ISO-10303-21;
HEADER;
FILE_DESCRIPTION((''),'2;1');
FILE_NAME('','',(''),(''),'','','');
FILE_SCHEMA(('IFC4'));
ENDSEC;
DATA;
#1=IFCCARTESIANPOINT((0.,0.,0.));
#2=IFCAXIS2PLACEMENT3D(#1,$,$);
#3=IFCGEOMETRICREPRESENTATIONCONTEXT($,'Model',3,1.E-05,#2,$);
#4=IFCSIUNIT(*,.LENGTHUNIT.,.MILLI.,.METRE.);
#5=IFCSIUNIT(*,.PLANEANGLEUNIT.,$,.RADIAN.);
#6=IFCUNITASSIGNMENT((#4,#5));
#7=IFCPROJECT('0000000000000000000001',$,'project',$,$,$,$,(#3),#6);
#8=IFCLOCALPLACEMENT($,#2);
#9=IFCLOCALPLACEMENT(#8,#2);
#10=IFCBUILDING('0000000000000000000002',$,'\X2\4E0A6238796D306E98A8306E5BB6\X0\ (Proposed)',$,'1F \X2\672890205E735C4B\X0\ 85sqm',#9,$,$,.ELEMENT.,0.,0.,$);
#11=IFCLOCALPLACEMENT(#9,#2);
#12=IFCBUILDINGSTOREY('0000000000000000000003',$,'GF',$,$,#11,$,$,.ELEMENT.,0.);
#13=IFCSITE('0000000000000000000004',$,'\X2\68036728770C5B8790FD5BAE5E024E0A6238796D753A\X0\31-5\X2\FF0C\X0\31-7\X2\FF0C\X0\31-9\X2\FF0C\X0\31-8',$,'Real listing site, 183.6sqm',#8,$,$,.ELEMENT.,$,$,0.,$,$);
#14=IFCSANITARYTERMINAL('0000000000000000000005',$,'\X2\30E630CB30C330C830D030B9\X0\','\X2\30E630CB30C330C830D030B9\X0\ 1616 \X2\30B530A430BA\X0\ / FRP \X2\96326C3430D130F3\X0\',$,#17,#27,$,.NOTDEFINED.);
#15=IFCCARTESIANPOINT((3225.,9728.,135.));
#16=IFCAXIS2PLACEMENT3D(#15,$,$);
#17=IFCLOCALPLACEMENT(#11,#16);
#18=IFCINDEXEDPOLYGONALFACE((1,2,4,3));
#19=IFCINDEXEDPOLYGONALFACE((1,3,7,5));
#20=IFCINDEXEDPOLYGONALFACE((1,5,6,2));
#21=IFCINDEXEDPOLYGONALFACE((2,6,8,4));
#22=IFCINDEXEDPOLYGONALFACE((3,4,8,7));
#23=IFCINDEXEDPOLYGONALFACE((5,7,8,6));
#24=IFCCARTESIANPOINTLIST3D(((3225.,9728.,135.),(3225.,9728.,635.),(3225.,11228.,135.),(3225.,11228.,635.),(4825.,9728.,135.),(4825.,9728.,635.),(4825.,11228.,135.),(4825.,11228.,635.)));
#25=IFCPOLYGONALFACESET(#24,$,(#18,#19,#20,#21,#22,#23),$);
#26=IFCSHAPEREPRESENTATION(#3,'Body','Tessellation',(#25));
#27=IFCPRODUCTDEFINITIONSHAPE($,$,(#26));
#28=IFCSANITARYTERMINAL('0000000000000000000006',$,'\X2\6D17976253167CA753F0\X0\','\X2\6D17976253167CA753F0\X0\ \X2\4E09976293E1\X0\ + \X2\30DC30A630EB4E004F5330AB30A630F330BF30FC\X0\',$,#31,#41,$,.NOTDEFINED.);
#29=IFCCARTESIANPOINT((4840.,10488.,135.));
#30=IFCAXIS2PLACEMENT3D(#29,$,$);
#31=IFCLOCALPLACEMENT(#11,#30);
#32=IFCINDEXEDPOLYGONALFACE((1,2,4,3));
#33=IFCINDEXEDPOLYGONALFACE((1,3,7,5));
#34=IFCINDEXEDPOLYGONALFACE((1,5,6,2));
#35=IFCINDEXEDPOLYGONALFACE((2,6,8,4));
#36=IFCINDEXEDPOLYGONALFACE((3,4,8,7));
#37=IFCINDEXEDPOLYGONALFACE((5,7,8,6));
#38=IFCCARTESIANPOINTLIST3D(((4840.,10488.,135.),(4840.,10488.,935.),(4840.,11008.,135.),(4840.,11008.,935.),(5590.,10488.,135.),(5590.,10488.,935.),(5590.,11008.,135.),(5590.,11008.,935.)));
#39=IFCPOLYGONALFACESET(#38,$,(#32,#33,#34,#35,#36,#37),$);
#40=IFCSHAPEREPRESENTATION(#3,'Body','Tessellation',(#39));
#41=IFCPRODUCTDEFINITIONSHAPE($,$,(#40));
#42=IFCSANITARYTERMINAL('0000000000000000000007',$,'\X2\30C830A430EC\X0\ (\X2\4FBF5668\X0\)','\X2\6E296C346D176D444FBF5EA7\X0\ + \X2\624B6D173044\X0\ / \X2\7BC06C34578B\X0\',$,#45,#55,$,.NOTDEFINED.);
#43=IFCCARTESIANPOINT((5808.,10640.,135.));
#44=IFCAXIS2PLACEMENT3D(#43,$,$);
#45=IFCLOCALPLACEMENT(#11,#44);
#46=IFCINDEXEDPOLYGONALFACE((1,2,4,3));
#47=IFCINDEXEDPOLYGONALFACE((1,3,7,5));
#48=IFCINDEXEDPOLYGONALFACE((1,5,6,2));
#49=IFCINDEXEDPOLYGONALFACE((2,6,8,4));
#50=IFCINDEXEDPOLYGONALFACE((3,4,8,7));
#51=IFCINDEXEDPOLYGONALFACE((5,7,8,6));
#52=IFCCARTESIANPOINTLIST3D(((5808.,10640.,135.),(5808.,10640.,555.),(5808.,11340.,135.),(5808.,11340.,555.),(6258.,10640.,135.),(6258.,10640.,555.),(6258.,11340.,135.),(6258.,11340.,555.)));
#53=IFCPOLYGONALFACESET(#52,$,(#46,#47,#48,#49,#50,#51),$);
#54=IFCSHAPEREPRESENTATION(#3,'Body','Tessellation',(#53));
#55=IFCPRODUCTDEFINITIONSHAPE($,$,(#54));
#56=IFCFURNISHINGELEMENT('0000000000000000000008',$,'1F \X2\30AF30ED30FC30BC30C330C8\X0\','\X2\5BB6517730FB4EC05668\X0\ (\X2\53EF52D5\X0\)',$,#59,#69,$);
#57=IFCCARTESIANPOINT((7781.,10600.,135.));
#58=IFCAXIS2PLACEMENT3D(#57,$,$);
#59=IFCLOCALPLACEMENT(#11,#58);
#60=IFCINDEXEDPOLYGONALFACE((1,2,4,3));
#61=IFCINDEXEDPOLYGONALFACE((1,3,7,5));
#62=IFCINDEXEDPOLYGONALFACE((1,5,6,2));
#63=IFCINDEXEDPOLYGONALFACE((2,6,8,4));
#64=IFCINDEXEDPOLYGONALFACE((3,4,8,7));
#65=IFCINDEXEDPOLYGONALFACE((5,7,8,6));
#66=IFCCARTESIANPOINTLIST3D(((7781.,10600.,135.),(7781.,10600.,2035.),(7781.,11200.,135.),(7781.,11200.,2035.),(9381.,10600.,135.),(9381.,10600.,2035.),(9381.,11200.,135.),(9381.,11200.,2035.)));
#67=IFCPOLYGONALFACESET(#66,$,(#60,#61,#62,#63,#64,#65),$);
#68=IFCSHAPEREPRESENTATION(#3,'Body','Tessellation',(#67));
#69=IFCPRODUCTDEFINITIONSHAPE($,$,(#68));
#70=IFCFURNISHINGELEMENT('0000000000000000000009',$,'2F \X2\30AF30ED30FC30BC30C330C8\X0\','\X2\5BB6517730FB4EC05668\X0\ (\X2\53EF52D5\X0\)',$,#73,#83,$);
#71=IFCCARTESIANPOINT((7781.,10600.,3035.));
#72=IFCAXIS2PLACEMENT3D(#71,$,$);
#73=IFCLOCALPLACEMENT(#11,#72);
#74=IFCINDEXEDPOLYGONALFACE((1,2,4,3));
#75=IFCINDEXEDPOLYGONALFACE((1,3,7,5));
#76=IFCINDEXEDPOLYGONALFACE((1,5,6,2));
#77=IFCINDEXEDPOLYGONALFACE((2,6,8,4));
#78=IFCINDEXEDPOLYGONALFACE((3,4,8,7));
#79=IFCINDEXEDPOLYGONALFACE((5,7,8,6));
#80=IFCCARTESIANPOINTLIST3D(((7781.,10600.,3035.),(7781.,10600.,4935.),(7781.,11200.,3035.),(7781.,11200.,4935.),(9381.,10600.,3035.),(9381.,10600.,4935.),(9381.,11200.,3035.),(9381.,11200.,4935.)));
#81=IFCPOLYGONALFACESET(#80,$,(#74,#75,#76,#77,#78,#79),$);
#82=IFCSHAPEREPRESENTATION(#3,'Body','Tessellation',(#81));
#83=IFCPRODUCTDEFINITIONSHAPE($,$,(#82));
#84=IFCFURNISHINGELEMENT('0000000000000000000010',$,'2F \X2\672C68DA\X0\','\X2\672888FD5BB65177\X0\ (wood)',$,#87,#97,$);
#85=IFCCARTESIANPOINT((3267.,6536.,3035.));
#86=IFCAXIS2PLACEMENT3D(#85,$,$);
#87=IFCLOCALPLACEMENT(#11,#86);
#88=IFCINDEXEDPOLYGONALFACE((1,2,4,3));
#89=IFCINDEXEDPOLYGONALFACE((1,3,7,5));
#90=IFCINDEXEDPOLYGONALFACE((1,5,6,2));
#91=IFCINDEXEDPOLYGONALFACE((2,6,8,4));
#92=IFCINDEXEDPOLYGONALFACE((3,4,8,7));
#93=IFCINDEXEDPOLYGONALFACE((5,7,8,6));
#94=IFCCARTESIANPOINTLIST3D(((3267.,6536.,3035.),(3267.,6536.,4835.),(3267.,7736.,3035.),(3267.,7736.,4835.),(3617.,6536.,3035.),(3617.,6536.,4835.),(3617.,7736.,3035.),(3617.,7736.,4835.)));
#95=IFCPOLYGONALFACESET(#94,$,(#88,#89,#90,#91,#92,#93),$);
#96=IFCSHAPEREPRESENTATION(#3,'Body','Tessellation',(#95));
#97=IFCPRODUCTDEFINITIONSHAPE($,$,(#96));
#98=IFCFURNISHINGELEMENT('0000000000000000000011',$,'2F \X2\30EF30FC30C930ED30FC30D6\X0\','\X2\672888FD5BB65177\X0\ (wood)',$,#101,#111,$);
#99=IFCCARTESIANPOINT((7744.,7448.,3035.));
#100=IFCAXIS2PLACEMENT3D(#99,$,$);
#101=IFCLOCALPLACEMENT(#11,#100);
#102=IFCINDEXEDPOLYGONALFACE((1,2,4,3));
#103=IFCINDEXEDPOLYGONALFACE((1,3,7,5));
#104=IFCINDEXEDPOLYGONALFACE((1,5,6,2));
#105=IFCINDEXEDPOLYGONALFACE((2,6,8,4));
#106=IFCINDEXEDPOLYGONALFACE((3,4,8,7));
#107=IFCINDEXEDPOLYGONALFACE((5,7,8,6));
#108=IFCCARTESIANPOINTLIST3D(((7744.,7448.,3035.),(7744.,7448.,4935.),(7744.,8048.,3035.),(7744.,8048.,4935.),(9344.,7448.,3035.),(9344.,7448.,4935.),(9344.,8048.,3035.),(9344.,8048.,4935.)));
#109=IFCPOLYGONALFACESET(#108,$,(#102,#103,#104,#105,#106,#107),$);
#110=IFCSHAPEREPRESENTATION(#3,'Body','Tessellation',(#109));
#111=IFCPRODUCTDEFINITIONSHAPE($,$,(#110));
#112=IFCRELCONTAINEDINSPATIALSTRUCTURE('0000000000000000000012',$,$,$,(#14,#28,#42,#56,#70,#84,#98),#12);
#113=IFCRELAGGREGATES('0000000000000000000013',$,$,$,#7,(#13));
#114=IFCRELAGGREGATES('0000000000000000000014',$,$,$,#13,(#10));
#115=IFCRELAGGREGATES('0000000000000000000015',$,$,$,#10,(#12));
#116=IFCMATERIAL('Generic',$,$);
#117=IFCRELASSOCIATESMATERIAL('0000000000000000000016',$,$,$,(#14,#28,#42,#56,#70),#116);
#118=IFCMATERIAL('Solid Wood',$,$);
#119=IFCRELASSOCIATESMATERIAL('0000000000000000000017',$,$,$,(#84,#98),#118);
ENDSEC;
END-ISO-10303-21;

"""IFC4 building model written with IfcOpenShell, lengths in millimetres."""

from ifc_helpers import new_model, si_unit, frame, frame_2d, origin, place, context, project, spatial, rectangle, extrude, material, element, save


model = new_model("IFC4")

# Units and contexts
model_context = context("Model", 3, precision=1e-05, world=origin())
ifc_project = project(units=[si_unit("LENGTHUNIT", "METRE", prefix="MILLI"), si_unit("PLANEANGLEUNIT", "RADIAN")], contexts=[model_context])

# Site, building, storey
site_placement = place(None, origin())
site = spatial("IfcSite", under=ifc_project, at=site_placement, Name="栃木県宇都宮市上戸祭町31-5，31-7，31-9，31-8", ObjectType="Real listing site, 183.6sqm", CompositionType="ELEMENT", RefElevation=0.0)
building_placement = place(site_placement, origin())
building = spatial("IfcBuilding", under=site, at=building_placement, Name="上戸祭の風の家 (Proposed)", ObjectType="1F 木造平屋 85sqm", CompositionType="ELEMENT", ElevationOfRefHeight=0.0, ElevationOfTerrain=0.0)
storey_placement = place(building_placement, origin())
storey = spatial("IfcBuildingStorey", under=building, at=storey_placement, Name="GF", CompositionType="ELEMENT", Elevation=0.0)

# Shared definitions
ifc_material_1 = material(Name="Solid Wood")

# Shared definitions
ifc_material_2 = material(Name="Generic")

# Sanitary terminals
sanitary_terminal_1_placement = place(storey_placement, frame((3225.0, 9728.0, 135.0)))
element("IfcSanitaryTerminal", 1, at=sanitary_terminal_1_placement, inside=storey, material=ifc_material_2, Name="ユニットバス", Description="ユニットバス 1616 サイズ / FRP 防水パン", PredefinedType="NOTDEFINED", context=model_context, shape_type="SweptSolid", body=[
    extrude(rectangle(XDim=1600.0, YDim=1500.0, at=frame_2d((800.0, 750.0))), frame((3225.0, 9728.0, 135.0)), (0.0, 0.0, 1.0), 500.0),
])
sanitary_terminal_2_placement = place(storey_placement, frame((4840.0, 10488.0, 135.0)))
element("IfcSanitaryTerminal", 2, at=sanitary_terminal_2_placement, inside=storey, material=ifc_material_2, Name="洗面化粧台", Description="洗面化粧台 三面鏡 + ボウル一体カウンター", PredefinedType="NOTDEFINED", context=model_context, shape_type="SweptSolid", body=[
    extrude(rectangle(XDim=750.0, YDim=520.0, at=frame_2d((375.0, 260.0))), frame((4840.0, 10488.0, 135.0)), (0.0, 0.0, 1.0), 800.0),
])
sanitary_terminal_3_placement = place(storey_placement, frame((5808.0, 10640.0, 135.0)))
element("IfcSanitaryTerminal", 3, at=sanitary_terminal_3_placement, inside=storey, material=ifc_material_2, Name="トイレ (便器)", Description="温水洗浄便座 + 手洗い / 節水型", PredefinedType="NOTDEFINED", context=model_context, shape_type="SweptSolid", body=[
    extrude(rectangle(XDim=450.0, YDim=700.0, at=frame_2d((225.0, 350.0))), frame((5808.0, 10640.0, 135.0)), (0.0, 0.0, 1.0), 420.0),
])

# Furnishing elements
furnishing_1_placement = place(storey_placement, frame((7781.0, 10600.0, 135.0)))
element("IfcFurnishingElement", 4, at=furnishing_1_placement, inside=storey, material=ifc_material_2, Name="1F クローゼット", Description="家具・什器 (可動)", context=model_context, shape_type="SweptSolid", body=[
    extrude(rectangle(XDim=1600.0, YDim=600.0, at=frame_2d((800.0, 300.0))), frame((7781.0, 10600.0, 135.0)), (0.0, 0.0, 1.0), 1900.0),
])
furnishing_2_placement = place(storey_placement, frame((7781.0, 10600.0, 3035.0)))
element("IfcFurnishingElement", 5, at=furnishing_2_placement, inside=storey, material=ifc_material_2, Name="2F クローゼット", Description="家具・什器 (可動)", context=model_context, shape_type="SweptSolid", body=[
    extrude(rectangle(XDim=1600.0, YDim=600.0, at=frame_2d((800.0, 300.0))), frame((7781.0, 10600.0, 3035.0)), (0.0, 0.0, 1.0), 1900.0),
])
furnishing_3_placement = place(storey_placement, frame((3267.0, 6536.0, 3035.0)))
element("IfcFurnishingElement", 6, at=furnishing_3_placement, inside=storey, material=ifc_material_1, Name="2F 本棚", Description="木製家具 (wood)", context=model_context, shape_type="SweptSolid", body=[
    extrude(rectangle(XDim=350.0, YDim=1200.0, at=frame_2d((175.0, 600.0))), frame((3267.0, 6536.0, 3035.0)), (0.0, 0.0, 1.0), 1800.0),
])
furnishing_4_placement = place(storey_placement, frame((7744.0, 7448.0, 3035.0)))
element("IfcFurnishingElement", 7, at=furnishing_4_placement, inside=storey, material=ifc_material_1, Name="2F ワードローブ", Description="木製家具 (wood)", context=model_context, shape_type="SweptSolid", body=[
    extrude(rectangle(XDim=1600.0, YDim=600.0, at=frame_2d((800.0, 300.0))), frame((7744.0, 7448.0, 3035.0)), (0.0, 0.0, 1.0), 1900.0),
])

save(model, "model.ifc")
